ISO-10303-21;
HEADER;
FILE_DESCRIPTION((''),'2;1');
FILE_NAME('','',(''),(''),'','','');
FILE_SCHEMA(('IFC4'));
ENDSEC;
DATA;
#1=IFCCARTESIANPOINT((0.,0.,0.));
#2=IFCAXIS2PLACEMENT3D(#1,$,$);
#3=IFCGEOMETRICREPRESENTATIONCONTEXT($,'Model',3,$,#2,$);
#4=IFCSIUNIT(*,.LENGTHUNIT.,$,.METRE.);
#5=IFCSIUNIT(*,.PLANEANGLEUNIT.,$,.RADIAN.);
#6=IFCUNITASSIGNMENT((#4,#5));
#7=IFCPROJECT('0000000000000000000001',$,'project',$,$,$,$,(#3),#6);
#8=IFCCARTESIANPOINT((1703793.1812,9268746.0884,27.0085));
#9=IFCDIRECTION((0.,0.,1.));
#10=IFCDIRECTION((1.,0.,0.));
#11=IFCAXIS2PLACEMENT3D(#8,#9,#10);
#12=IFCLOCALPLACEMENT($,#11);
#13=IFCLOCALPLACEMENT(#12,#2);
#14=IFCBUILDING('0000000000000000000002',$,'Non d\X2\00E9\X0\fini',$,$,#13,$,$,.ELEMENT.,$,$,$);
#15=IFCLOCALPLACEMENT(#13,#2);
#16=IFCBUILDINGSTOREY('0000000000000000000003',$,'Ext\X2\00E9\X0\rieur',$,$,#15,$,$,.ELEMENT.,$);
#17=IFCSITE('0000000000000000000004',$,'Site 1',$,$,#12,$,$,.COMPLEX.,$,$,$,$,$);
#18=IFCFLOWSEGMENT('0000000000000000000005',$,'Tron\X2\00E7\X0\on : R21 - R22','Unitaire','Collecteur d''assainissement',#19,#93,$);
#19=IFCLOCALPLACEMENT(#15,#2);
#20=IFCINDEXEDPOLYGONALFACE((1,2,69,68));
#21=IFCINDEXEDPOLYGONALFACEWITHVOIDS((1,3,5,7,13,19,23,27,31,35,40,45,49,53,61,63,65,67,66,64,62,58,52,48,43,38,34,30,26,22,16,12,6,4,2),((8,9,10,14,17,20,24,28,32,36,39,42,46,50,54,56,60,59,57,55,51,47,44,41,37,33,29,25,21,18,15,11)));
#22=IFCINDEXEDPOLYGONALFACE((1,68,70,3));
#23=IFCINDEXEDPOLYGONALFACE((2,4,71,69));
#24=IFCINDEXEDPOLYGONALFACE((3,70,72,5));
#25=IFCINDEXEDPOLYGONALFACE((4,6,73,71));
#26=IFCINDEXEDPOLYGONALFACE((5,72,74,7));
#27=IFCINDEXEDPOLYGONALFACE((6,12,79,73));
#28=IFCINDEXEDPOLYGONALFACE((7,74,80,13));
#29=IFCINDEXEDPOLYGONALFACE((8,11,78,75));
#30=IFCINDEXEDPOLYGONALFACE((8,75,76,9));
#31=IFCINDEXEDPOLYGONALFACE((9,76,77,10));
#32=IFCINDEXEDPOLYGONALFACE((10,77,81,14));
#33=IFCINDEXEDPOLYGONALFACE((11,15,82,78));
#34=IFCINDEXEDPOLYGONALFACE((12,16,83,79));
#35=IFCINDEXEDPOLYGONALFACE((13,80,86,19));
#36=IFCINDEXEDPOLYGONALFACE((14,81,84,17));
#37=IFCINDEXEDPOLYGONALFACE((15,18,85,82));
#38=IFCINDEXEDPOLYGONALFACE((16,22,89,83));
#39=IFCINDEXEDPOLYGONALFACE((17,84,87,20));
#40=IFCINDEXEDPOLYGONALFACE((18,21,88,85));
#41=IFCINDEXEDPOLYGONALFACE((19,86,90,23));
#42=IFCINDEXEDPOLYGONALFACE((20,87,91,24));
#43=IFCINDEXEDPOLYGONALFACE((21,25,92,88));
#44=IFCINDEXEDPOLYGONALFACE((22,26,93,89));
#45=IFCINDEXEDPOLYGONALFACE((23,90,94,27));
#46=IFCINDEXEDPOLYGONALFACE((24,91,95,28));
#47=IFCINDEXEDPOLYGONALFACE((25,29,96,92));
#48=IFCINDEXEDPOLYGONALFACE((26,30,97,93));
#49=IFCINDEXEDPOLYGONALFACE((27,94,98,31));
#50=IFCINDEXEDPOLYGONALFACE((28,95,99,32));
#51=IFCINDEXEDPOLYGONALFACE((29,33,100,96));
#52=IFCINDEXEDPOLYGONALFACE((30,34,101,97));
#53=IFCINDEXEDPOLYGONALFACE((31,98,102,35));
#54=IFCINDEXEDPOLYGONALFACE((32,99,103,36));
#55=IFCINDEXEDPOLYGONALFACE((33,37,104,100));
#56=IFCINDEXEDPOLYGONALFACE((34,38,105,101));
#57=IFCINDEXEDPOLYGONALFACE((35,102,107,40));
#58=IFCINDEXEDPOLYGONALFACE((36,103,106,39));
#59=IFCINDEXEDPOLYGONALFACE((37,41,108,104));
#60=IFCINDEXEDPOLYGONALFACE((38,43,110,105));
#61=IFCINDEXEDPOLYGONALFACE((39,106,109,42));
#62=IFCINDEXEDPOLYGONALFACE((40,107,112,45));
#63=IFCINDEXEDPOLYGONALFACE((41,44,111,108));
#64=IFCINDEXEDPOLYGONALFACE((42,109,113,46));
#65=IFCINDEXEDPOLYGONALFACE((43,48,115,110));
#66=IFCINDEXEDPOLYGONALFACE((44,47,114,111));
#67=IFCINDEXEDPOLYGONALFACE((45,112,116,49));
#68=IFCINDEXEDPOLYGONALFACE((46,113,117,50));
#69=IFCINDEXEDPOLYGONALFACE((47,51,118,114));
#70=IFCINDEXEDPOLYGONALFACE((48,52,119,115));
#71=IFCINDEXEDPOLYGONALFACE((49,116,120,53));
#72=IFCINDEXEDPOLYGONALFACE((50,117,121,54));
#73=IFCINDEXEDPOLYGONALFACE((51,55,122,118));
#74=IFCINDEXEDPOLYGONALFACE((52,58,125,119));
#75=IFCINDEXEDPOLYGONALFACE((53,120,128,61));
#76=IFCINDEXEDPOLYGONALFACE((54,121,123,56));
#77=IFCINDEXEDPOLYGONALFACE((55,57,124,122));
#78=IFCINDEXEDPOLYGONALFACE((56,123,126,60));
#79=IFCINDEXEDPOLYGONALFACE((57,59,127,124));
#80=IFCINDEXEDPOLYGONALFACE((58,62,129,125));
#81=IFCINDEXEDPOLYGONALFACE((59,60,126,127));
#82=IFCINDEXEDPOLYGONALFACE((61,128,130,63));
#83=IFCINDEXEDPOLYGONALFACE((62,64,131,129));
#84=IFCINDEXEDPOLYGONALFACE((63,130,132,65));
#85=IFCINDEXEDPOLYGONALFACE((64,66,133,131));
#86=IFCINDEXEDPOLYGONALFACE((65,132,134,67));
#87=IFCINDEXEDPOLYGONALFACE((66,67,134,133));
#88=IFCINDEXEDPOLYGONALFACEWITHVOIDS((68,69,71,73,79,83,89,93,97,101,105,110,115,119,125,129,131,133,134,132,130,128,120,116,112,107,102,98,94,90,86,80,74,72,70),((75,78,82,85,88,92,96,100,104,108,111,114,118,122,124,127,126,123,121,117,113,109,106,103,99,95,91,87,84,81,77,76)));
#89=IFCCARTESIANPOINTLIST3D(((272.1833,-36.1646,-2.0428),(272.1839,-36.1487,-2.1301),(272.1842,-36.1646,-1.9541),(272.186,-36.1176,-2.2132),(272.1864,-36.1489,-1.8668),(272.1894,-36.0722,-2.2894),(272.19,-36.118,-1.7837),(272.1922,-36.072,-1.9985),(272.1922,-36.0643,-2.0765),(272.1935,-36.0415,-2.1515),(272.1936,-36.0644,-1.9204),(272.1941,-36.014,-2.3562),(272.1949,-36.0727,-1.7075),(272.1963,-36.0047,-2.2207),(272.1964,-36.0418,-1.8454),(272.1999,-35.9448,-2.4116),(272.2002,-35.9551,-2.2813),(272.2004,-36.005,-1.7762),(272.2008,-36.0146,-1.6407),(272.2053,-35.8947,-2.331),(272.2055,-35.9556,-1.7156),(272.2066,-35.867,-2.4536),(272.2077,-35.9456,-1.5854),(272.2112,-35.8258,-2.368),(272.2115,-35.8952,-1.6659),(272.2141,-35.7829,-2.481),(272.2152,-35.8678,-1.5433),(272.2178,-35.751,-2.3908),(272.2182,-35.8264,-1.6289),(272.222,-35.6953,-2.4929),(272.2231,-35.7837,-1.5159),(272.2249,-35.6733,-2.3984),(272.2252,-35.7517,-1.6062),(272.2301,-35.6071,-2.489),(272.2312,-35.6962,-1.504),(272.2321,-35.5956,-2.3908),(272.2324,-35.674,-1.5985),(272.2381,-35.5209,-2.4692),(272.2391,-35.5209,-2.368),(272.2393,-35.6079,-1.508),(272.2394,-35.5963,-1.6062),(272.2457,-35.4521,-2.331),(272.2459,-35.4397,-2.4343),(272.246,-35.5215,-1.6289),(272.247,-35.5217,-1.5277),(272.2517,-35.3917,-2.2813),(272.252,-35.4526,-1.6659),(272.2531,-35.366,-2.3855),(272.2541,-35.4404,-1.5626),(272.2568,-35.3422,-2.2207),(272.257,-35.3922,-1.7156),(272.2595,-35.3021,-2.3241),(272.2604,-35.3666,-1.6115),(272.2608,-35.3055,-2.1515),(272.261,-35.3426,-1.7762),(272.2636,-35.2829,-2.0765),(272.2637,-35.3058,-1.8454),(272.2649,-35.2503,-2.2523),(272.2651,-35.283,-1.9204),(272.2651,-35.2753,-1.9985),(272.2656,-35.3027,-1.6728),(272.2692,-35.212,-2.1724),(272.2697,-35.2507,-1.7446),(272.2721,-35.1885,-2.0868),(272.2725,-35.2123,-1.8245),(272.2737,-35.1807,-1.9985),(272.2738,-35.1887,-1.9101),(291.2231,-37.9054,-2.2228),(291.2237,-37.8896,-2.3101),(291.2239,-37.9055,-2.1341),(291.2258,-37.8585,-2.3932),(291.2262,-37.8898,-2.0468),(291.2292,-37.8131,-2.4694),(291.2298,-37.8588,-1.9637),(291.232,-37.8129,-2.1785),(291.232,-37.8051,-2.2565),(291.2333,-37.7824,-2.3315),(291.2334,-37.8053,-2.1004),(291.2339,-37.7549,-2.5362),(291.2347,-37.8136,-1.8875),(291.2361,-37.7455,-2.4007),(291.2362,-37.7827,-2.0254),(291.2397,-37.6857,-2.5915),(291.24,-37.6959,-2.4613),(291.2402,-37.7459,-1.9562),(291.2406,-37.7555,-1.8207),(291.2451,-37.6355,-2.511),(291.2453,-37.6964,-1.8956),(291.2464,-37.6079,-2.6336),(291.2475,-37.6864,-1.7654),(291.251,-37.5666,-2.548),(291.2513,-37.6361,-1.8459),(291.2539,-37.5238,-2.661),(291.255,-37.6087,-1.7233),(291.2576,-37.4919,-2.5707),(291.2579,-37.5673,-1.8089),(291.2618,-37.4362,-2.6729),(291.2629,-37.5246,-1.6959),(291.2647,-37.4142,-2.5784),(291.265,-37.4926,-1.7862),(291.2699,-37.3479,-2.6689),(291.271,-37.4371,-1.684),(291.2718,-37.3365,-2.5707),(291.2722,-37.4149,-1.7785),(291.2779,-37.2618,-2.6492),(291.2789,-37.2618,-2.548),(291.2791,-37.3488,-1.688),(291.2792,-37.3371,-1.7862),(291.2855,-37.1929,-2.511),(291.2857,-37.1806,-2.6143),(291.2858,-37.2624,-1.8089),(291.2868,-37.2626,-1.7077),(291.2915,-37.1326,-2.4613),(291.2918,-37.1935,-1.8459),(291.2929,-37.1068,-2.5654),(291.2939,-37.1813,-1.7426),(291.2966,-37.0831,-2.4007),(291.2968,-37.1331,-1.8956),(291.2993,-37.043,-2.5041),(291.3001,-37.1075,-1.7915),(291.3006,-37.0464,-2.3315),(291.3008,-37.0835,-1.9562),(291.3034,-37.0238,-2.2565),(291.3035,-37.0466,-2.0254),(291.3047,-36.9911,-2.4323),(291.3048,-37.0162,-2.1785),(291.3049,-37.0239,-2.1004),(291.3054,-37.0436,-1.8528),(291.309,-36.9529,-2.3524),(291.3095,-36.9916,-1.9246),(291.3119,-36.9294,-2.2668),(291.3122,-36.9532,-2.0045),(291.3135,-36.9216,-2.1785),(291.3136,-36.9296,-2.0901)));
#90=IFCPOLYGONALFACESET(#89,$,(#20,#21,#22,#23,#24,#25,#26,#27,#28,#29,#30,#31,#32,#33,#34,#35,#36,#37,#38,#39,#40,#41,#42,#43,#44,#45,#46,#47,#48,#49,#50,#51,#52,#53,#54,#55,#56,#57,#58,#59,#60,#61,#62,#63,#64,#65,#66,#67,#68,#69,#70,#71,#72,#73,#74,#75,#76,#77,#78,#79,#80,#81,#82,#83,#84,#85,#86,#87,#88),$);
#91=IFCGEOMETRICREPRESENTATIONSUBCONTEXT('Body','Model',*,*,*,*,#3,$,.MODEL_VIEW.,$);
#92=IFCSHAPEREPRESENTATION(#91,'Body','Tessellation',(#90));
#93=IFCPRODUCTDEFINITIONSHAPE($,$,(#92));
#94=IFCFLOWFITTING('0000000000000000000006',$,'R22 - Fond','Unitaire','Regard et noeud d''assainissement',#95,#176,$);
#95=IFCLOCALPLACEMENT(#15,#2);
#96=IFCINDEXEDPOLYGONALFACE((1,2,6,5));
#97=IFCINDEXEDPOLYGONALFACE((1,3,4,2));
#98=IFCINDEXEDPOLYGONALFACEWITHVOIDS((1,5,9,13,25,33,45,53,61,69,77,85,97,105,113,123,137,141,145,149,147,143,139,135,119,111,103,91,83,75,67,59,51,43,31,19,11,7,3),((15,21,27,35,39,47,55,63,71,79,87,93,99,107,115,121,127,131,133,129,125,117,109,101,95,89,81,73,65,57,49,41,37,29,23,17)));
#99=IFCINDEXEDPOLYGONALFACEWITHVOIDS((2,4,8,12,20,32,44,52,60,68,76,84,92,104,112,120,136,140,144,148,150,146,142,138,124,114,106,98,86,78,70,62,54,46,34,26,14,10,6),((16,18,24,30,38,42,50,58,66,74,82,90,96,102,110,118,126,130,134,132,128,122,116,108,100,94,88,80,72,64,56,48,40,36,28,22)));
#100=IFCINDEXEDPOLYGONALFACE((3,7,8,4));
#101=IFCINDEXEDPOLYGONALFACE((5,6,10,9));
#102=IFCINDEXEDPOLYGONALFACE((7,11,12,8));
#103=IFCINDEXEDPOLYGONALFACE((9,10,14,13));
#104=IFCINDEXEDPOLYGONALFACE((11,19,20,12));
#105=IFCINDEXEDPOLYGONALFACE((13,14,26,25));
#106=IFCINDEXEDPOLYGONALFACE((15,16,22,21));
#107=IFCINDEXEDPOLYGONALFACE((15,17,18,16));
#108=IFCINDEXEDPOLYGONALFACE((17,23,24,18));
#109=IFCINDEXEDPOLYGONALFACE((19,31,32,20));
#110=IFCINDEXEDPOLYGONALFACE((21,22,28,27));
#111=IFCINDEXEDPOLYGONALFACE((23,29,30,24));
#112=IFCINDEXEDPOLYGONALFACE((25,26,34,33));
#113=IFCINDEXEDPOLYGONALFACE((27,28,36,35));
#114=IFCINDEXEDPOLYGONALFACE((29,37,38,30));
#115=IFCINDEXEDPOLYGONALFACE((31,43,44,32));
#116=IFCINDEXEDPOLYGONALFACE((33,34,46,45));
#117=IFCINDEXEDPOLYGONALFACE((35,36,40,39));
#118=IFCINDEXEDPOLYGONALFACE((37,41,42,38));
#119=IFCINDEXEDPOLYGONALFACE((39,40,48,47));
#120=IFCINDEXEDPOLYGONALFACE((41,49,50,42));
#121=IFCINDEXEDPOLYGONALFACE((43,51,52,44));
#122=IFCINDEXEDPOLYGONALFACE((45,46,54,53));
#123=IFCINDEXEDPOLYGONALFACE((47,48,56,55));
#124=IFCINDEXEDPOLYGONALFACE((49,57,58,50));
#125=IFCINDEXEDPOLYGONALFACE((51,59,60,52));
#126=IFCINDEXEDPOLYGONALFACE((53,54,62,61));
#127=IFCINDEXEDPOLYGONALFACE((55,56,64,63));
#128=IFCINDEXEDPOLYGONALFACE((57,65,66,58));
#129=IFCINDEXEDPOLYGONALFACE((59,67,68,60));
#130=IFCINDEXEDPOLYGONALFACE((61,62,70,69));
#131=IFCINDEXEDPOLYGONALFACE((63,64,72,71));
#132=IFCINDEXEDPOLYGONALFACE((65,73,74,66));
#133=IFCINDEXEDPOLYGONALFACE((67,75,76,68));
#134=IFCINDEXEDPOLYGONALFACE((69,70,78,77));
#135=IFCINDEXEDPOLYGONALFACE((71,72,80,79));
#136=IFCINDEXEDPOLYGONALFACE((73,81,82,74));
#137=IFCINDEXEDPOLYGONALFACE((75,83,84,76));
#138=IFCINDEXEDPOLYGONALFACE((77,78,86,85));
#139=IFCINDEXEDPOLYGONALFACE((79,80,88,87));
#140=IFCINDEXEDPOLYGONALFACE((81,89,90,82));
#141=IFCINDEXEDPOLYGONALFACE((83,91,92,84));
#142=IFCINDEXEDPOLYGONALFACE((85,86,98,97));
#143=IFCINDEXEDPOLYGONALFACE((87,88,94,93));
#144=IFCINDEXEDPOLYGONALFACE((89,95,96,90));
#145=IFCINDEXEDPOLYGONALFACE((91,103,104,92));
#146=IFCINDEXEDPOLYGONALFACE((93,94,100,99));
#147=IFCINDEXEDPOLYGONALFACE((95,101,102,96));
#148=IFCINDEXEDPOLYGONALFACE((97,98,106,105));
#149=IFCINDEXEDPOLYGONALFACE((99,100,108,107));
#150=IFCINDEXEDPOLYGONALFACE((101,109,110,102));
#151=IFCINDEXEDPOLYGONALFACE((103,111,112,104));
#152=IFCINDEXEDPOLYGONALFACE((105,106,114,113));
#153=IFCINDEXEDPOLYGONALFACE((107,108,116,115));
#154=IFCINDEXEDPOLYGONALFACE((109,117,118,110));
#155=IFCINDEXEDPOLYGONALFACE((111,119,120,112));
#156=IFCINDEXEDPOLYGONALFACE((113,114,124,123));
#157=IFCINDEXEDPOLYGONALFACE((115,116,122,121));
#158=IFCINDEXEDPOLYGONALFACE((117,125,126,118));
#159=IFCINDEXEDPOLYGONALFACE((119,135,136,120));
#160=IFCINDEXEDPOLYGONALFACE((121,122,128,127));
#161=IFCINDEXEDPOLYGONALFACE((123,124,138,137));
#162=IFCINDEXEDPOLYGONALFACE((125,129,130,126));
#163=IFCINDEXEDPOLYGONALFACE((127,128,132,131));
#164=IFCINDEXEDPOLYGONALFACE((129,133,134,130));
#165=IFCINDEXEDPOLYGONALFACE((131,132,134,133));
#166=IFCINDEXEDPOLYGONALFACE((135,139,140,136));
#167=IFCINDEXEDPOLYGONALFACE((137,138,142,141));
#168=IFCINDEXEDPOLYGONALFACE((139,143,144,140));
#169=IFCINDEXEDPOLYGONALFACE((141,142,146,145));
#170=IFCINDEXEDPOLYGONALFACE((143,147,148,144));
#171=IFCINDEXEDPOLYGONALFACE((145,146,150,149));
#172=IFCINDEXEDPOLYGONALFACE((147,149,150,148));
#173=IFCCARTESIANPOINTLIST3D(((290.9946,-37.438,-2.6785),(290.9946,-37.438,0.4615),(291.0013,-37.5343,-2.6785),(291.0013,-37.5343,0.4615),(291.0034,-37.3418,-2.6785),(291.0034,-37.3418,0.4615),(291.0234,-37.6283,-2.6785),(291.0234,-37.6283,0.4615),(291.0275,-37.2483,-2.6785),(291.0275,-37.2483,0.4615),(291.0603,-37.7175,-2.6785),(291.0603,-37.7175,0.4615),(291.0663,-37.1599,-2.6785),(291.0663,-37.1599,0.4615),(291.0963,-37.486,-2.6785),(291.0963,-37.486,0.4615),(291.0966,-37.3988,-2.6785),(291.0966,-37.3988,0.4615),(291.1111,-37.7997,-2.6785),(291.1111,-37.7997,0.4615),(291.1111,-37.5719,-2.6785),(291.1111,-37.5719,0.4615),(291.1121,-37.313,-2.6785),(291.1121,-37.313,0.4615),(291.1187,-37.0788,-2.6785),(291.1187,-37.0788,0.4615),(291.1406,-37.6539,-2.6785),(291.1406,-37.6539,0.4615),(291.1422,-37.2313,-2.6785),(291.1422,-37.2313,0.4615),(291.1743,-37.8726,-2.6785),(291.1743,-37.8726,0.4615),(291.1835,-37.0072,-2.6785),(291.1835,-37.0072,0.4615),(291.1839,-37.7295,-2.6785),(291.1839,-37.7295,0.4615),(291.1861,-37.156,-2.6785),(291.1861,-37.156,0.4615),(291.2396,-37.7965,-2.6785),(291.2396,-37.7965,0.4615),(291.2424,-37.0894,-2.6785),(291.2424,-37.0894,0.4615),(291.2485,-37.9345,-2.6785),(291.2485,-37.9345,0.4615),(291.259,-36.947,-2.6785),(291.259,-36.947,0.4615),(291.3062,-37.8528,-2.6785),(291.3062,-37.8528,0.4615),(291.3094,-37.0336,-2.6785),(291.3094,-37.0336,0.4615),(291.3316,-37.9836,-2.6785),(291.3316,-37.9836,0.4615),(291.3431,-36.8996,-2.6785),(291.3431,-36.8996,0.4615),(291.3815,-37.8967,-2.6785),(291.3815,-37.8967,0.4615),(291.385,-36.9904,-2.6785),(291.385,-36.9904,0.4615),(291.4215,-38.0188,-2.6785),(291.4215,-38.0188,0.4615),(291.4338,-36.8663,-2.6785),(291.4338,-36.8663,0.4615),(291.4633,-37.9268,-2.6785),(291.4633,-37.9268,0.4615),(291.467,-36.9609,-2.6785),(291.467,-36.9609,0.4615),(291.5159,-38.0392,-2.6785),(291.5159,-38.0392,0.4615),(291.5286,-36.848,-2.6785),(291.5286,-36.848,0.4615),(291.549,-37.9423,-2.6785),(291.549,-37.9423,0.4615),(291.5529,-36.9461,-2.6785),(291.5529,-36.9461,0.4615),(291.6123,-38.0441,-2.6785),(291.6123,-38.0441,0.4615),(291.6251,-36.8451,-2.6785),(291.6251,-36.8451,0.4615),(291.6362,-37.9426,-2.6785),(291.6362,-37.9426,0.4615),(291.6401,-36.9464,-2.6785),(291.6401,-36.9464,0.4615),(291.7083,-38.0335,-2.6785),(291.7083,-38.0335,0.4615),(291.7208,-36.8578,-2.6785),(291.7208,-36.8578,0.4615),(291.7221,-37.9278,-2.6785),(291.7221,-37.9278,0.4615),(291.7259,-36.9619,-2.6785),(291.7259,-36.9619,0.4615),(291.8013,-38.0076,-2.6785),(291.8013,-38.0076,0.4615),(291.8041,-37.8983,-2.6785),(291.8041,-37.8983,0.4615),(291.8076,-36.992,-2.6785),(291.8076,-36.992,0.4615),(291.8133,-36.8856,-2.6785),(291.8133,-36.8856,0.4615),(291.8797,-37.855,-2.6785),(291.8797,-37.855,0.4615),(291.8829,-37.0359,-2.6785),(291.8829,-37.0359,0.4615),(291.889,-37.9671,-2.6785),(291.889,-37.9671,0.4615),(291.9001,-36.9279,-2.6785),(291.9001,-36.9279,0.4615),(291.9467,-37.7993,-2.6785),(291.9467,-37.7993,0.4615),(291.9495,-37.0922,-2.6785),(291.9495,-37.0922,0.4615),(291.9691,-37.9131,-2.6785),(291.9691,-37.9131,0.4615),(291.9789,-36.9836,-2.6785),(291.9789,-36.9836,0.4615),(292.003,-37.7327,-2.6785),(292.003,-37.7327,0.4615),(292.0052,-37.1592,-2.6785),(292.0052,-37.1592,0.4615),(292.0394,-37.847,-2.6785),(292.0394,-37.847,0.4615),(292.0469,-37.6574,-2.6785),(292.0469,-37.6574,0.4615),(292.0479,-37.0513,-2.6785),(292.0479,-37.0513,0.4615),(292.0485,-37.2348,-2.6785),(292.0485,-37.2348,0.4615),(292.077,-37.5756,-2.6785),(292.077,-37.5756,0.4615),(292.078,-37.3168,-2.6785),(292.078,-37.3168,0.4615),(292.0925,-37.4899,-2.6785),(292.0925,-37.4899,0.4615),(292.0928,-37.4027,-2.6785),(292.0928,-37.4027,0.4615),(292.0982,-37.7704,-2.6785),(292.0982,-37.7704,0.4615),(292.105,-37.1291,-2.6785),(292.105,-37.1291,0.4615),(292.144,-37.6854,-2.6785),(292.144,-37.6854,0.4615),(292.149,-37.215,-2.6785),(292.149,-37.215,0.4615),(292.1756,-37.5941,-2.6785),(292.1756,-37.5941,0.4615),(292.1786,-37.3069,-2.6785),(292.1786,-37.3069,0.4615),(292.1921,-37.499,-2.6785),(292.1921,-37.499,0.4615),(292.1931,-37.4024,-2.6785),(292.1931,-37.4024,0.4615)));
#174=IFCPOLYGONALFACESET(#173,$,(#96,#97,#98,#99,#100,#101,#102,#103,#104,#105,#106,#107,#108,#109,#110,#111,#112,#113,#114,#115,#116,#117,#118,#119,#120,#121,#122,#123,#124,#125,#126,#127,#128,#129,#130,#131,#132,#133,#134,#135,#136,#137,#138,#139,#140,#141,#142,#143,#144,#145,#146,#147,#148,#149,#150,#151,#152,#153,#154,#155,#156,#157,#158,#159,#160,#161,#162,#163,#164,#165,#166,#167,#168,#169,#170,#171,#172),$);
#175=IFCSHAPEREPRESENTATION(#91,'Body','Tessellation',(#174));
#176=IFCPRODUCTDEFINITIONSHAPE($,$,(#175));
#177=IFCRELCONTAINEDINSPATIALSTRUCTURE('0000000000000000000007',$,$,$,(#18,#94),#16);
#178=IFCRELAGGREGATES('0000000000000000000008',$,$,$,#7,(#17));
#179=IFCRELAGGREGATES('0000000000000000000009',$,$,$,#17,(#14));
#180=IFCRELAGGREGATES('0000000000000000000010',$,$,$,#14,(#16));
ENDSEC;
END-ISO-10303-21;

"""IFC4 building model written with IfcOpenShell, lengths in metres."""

from ifc_helpers import new_model, si_unit, frame, origin, origin_2d, place, context, subcontext, project, spatial, hollow_circle, extrude, element, save


model = new_model("IFC4")

# Units and contexts
model_context = context("Model", 3, world=origin())
body_context = subcontext(model_context, "Body", "Model", "MODEL_VIEW")
ifc_project = project(units=[si_unit("LENGTHUNIT", "METRE"), si_unit("PLANEANGLEUNIT", "RADIAN")], contexts=[model_context])

# Site, building, storey
site_placement = place(None, frame((1703793.1812, 9268746.0884, 27.0085), z_axis=(0.0, 0.0, 1.0), x_axis=(1.0, 0.0, 0.0)))
site = spatial("IfcSite", under=ifc_project, at=site_placement, Name="Site 1", CompositionType="COMPLEX")
building_placement = place(site_placement, origin())
building = spatial("IfcBuilding", under=site, at=building_placement, Name="Non défini", CompositionType="ELEMENT")
storey_placement = place(building_placement, origin())
storey = spatial("IfcBuildingStorey", under=building, at=storey_placement, Name="Extérieur", CompositionType="ELEMENT")

# Flow segment
flow_segment_1_placement = place(storey_placement, origin())
element("IfcFlowSegment", 1, at=flow_segment_1_placement, inside=storey, Name="Tronçon : R21 - R22", Description="Unitaire", ObjectType="Collecteur d'assainissement", context=body_context, shape_type="SweptSolid", body=[
    extrude(hollow_circle(Radius=0.495, WallThickness=0.095, at=origin_2d()), frame((272.2286, -35.6736, -1.9985), z_axis=(0.995802, -0.09105, -0.009413), x_axis=(0.091054, 0.995846, 0.0)), (0.0, 0.0, 1.0), 19.1201),
])

# Flow fitting
flow_fitting_1_placement = place(storey_placement, origin())
element("IfcFlowFitting", 2, at=flow_fitting_1_placement, inside=storey, Name="R22 - Fond", Description="Unitaire", ObjectType="Regard et noeud d'assainissement", context=body_context, shape_type="SweptSolid", body=[
    extrude(hollow_circle(Radius=0.6, WallThickness=0.1, at=origin_2d()), frame((291.5946, -37.4443, -2.6785), z_axis=(0.0, 0.0, 1.0), x_axis=(0.995846, -0.091054, 0.0)), (0.0, 0.0, 1.0), 3.14),
])

save(model, "model.ifc")
